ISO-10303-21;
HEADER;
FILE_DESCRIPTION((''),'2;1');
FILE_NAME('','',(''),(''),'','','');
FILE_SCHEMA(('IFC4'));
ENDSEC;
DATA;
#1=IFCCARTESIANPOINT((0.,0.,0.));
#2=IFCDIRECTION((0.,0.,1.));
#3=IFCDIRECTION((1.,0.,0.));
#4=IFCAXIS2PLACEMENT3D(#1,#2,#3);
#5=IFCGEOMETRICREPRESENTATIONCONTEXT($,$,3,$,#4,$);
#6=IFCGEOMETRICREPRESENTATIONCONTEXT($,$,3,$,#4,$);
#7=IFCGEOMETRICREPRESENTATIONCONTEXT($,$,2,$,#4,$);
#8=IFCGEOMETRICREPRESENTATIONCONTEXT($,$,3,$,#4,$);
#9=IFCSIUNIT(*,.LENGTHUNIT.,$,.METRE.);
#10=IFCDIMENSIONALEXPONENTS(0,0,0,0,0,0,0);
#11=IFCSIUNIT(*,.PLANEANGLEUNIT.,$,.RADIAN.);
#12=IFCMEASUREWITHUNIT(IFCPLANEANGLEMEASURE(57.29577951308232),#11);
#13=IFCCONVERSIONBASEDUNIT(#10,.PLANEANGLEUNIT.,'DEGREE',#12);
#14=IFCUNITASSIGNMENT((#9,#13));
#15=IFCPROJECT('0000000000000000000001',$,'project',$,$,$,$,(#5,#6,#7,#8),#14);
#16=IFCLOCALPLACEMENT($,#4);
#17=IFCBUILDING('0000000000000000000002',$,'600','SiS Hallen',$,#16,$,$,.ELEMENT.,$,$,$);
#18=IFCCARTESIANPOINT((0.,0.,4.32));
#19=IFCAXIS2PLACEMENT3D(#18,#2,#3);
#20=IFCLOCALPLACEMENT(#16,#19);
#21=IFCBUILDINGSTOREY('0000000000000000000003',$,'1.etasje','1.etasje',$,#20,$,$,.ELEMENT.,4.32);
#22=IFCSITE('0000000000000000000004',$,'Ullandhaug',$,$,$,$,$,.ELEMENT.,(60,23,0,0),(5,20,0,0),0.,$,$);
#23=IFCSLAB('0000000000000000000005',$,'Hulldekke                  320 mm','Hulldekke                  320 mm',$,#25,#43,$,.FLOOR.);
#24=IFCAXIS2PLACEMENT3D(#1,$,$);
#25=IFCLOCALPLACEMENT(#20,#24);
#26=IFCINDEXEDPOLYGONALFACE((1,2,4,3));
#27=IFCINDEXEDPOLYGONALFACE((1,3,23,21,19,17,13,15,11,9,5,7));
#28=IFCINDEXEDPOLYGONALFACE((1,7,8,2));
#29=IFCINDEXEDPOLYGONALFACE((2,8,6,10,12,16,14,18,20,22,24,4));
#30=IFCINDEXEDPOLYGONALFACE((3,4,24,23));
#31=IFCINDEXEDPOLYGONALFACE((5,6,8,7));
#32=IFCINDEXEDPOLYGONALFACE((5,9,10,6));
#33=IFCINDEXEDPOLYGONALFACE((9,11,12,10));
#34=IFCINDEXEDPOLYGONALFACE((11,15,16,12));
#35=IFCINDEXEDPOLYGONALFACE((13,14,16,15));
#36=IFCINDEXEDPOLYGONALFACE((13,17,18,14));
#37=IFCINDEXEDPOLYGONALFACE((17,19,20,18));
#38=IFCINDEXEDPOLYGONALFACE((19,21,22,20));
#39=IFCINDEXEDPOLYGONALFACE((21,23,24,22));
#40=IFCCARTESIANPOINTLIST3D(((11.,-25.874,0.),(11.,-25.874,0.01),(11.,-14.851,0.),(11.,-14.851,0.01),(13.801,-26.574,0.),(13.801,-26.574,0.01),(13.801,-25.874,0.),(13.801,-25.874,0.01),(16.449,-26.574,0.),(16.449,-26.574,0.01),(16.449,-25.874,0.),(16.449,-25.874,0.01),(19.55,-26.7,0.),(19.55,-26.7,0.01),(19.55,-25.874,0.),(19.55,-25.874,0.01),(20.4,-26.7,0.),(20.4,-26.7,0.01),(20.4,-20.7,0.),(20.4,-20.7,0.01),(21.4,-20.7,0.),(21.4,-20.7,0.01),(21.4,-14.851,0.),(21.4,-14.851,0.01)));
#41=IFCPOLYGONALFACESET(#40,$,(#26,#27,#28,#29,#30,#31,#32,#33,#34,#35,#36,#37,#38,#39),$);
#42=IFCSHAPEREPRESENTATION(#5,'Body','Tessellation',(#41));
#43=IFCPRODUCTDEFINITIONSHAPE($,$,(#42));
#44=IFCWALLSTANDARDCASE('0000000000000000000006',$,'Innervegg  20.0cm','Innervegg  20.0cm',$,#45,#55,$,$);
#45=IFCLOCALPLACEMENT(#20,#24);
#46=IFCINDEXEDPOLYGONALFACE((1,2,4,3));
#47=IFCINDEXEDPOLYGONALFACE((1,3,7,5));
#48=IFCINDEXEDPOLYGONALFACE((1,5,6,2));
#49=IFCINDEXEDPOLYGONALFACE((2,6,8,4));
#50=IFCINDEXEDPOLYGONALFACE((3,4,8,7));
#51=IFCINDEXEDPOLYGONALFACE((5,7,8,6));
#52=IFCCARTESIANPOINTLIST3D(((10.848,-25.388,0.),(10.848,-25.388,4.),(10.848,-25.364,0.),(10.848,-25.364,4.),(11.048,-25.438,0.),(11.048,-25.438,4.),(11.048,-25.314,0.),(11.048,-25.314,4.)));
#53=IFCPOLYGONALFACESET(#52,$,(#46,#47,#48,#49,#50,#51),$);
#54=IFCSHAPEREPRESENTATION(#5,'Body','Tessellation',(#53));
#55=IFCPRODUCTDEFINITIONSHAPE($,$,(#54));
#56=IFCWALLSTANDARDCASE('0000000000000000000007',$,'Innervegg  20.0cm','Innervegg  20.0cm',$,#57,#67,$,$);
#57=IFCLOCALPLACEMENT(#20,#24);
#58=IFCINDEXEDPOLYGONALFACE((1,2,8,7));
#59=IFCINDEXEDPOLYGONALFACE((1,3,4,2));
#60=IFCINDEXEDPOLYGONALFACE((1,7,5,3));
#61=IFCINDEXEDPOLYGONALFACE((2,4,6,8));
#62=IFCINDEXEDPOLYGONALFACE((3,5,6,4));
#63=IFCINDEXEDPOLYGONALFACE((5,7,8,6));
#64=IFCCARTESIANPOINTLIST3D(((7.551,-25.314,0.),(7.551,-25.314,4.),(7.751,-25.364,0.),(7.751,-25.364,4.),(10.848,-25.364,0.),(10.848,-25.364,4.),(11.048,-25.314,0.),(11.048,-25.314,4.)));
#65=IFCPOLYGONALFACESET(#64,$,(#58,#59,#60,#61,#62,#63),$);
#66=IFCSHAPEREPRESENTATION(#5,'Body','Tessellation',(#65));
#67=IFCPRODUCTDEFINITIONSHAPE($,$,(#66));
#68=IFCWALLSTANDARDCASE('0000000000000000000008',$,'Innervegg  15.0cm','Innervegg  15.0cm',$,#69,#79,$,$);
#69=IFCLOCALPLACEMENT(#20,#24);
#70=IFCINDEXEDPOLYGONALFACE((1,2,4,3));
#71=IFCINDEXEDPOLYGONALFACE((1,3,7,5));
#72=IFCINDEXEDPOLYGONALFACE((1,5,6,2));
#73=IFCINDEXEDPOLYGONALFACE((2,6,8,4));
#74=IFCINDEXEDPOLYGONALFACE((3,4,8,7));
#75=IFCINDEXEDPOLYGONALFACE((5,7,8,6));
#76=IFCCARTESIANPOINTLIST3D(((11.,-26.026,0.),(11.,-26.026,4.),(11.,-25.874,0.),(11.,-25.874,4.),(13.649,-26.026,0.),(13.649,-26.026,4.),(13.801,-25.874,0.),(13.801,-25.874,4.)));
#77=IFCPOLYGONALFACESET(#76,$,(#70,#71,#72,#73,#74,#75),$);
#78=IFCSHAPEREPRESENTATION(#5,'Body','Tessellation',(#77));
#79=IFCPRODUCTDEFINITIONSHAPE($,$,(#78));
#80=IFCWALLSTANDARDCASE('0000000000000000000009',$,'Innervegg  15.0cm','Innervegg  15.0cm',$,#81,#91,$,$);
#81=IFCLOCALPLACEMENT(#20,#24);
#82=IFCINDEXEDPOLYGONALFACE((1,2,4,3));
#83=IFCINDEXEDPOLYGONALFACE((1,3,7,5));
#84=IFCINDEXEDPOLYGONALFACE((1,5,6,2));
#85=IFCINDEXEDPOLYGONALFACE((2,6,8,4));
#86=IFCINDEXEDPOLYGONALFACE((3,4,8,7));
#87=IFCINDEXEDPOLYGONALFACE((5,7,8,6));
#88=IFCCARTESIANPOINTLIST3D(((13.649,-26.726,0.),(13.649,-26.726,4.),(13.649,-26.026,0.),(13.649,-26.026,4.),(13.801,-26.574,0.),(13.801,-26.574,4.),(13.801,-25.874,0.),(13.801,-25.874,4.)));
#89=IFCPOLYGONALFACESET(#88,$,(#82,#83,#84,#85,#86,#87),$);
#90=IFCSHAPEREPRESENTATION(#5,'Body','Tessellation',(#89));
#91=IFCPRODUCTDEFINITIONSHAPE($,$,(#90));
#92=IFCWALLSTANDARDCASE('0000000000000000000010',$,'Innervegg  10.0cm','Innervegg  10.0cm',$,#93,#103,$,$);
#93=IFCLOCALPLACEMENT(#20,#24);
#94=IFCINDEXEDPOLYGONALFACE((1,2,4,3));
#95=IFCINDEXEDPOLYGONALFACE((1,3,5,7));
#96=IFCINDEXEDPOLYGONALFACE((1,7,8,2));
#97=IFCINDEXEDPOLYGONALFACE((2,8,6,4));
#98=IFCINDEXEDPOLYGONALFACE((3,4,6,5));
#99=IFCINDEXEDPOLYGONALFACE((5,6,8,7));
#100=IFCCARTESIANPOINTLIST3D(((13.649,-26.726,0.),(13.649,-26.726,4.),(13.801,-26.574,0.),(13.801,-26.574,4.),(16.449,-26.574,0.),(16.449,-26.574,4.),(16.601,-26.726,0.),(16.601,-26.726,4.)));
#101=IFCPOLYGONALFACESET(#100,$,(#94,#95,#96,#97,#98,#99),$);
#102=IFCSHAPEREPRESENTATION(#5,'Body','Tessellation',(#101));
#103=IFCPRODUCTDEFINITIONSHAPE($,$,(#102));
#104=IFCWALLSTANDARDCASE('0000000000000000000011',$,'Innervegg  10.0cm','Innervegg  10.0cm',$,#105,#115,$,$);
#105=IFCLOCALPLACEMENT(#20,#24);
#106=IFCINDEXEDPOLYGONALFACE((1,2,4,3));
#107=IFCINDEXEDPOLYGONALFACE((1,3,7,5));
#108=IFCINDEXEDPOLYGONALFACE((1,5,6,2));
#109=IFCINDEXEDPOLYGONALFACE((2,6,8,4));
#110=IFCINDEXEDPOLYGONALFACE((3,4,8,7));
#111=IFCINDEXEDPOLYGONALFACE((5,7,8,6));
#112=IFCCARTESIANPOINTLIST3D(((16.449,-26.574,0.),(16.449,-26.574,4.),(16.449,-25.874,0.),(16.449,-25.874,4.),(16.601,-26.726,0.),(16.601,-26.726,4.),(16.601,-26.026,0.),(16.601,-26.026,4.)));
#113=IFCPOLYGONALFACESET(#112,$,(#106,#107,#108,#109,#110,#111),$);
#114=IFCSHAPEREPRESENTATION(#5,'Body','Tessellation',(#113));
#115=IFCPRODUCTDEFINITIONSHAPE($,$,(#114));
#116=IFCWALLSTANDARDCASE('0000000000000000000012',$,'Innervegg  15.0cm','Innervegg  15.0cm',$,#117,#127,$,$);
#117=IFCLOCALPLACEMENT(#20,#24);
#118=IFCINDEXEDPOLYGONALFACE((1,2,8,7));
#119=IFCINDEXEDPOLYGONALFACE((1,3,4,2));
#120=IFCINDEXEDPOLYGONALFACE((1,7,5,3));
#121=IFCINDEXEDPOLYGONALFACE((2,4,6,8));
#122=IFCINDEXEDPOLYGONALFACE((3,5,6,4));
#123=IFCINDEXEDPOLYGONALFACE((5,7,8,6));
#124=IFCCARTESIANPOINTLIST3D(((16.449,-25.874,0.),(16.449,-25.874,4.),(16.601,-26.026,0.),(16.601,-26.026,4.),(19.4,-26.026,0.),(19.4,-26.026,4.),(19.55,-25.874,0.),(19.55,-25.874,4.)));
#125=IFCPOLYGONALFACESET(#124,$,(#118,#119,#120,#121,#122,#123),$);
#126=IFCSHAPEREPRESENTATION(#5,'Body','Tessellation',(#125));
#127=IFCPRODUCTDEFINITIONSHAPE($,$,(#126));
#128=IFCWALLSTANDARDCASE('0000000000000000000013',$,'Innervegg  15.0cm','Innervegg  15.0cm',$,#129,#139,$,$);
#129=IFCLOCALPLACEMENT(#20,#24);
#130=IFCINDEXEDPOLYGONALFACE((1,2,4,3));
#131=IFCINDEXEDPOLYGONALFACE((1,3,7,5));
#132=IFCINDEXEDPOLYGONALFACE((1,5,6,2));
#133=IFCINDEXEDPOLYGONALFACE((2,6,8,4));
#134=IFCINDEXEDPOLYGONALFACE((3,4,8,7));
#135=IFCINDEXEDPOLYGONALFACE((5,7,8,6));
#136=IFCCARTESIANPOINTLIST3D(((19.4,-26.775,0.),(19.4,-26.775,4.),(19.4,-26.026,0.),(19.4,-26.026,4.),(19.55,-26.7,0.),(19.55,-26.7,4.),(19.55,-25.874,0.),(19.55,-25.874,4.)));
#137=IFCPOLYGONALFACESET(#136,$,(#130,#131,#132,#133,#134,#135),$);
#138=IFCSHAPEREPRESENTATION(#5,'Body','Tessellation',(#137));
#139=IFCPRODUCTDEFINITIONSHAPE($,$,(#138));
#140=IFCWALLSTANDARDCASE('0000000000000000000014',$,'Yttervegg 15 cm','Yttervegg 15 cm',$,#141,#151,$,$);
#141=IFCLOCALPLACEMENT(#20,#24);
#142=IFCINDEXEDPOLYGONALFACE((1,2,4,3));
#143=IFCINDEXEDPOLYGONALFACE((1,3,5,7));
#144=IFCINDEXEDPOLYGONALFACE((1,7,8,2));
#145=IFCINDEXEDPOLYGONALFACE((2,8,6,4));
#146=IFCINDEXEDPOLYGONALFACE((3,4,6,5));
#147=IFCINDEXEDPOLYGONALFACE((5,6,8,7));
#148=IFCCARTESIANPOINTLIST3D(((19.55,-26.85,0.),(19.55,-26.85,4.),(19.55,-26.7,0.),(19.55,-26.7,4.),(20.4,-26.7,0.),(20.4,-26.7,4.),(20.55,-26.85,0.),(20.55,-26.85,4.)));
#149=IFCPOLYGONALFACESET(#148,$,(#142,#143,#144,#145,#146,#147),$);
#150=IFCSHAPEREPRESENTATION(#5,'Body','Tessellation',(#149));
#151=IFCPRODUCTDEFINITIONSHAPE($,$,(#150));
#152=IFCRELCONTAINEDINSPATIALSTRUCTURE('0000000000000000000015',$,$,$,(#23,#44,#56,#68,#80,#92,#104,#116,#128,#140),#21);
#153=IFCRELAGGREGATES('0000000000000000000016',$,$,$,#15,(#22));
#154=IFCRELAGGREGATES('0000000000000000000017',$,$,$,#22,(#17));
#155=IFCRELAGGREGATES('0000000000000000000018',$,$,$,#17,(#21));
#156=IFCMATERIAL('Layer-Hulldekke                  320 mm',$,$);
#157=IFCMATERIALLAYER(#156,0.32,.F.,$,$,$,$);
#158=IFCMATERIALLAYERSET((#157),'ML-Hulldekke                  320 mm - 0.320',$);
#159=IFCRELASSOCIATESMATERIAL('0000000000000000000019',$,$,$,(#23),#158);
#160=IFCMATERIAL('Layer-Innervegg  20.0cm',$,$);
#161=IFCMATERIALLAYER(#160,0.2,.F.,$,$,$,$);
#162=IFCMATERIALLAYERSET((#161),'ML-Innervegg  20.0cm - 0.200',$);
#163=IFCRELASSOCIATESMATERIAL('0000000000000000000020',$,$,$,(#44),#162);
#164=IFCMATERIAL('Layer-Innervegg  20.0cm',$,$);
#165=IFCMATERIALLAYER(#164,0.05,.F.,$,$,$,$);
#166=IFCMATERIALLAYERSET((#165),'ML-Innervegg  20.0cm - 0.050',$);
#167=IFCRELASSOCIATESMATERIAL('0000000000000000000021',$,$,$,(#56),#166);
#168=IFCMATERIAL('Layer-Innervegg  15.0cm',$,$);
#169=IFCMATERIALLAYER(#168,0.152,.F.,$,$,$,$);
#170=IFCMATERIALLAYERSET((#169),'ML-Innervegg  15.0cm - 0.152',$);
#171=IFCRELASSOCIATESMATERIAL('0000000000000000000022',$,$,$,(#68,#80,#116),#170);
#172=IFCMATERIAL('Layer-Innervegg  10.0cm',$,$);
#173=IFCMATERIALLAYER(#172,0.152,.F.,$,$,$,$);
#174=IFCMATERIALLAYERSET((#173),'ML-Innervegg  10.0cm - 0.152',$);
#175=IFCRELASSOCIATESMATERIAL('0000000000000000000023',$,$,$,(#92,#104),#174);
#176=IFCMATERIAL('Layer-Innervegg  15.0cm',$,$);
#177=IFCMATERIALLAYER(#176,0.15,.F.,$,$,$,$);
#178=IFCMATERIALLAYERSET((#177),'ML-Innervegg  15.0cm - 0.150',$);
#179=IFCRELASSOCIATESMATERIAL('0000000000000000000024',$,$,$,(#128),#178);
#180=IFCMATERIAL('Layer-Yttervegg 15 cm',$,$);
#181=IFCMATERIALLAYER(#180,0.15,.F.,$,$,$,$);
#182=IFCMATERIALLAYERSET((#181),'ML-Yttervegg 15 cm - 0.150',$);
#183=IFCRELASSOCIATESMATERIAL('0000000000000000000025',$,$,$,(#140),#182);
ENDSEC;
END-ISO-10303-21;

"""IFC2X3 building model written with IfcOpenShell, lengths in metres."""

from ifc_helpers import new_model, entity, si_unit, converted_unit, frame, origin_with_axes, place, context, project, spatial, polyline, outline, extrude, material, layer, layer_set, layer_usage, element, save


model = new_model("IFC2X3")

# Units and contexts
context_of_model_1 = context(None, 3, world=origin_with_axes())
context_of_model_2 = context(None, 3, world=origin_with_axes())
context_of_model_3 = context(None, 2, world=origin_with_axes())
context_of_model_4 = context(None, 3, world=origin_with_axes())
ifc_project = project(units=[si_unit("LENGTHUNIT", "METRE"), converted_unit("PLANEANGLEUNIT", "DEGREE", entity("IfcPlaneAngleMeasure", 57.29577951308232), si_unit("PLANEANGLEUNIT", "RADIAN"), dimensions=[0, 0, 0, 0, 0, 0, 0])], contexts=[context_of_model_1, context_of_model_2, context_of_model_3, context_of_model_4])

# Site, building, storey
site = spatial("IfcSite", under=ifc_project, Name="Ullandhaug", CompositionType="ELEMENT", RefLatitude=(60, 23, 0, 0), RefLongitude=(5, 20, 0, 0), RefElevation=0.0)
building_placement = place(None, origin_with_axes())
building = spatial("IfcBuilding", under=site, at=building_placement, Name="600", Description="SiS Hallen", CompositionType="ELEMENT")
storey_placement = place(building_placement, frame((0.0, 0.0, 4.32), z_axis=(0.0, 0.0, 1.0), x_axis=(1.0, 0.0, 0.0)))
storey = spatial("IfcBuildingStorey", under=building, at=storey_placement, Name="1.etasje", Description="1.etasje", CompositionType="ELEMENT", Elevation=4.32)

# Slab
ifc_material_1 = material(Name="Layer-Hulldekke                  320 mm")
ifc_layer_1 = layer(ifc_material_1, 0.32, ventilated=False)
ifc_layer_set_1 = layer_set([ifc_layer_1], Name="ML-Hulldekke                  320 mm - 0.320")
ifc_layer_usage_1 = layer_usage(ifc_layer_set_1, "AXIS2", "POSITIVE", 0.0)
slab_placement = place(storey_placement, frame((11.0, -25.874, 0.0), z_axis=(0.0, 0.0, 1.0), x_axis=(1.0, 0.0, 0.0)))
element("IfcSlab", 1, at=slab_placement, inside=storey, material=ifc_layer_usage_1, Name="Hulldekke                  320 mm", Description="Hulldekke                  320 mm", PredefinedType="FLOOR", context=context_of_model_1, shape_type="SweptSolid", body=[
    extrude(outline(polyline([(0.0, 0.0), (2.801, 0.0), (2.801, 0.7), (5.449, 0.7), (5.449, 0.0), (8.55, 0.0), (8.55, 0.826), (9.4, 0.826), (9.4, -5.174), (10.4, -5.174), (10.4, -11.023), (0.0, -11.023), (0.0, 0.0)])), frame((0.0, 0.0, 0.0), z_axis=(0.0, 0.0, -1.0), x_axis=(1.0, 0.0, 0.0)), (0.0, 0.0, -1.0), 0.01),
])

# Walls
ifc_material_2 = material(Name="Layer-Innervegg  20.0cm")
ifc_layer_2 = layer(ifc_material_2, 0.2, ventilated=False)
ifc_layer_set_2 = layer_set([ifc_layer_2], Name="ML-Innervegg  20.0cm - 0.200")
ifc_layer_usage_2 = layer_usage(ifc_layer_set_2, "AXIS2", "POSITIVE", 0.0)
wall_1_placement = place(storey_placement, frame((11.048, -25.438, 0.0), z_axis=(0.0, 0.0, 1.0), x_axis=(0.0, 1.0, 0.0)))
element("IfcWallStandardCase", 2, at=wall_1_placement, inside=storey, material=ifc_layer_usage_2, Name="Innervegg  20.0cm", Description="Innervegg  20.0cm", context=context_of_model_1, shape_type="SweptSolid", body=[
    extrude(outline(polyline([(0.0, 0.0), (0.124, 0.0), (0.074, 0.2), (0.05, 0.2), (0.0, 0.0)])), frame((0.0, 0.0, 0.0), z_axis=(0.0, 0.0, 1.0), x_axis=(1.0, 0.0, 0.0)), (0.0, 0.0, 1.0), 4.0),
])
ifc_material_3 = material(Name="Layer-Innervegg  20.0cm")
ifc_layer_3 = layer(ifc_material_3, 0.05, ventilated=False)
ifc_layer_set_3 = layer_set([ifc_layer_3], Name="ML-Innervegg  20.0cm - 0.050")
ifc_layer_usage_3 = layer_usage(ifc_layer_set_3, "AXIS2", "POSITIVE", 0.0)
wall_2_placement = place(storey_placement, frame((11.048, -25.314, 0.0), z_axis=(0.0, 0.0, 1.0), x_axis=(-1.0, 0.0, 0.0)))
element("IfcWallStandardCase", 3, at=wall_2_placement, inside=storey, material=ifc_layer_usage_3, Name="Innervegg  20.0cm", Description="Innervegg  20.0cm", context=context_of_model_1, shape_type="SweptSolid", body=[
    extrude(outline(polyline([(0.0, 0.0), (3.497, 0.0), (3.297, 0.05), (0.2, 0.05), (0.0, 0.0)])), frame((0.0, 0.0, 0.0), z_axis=(0.0, 0.0, 1.0), x_axis=(1.0, 0.0, 0.0)), (0.0, 0.0, 1.0), 4.0),
])
ifc_material_4 = material(Name="Layer-Innervegg  15.0cm")
ifc_layer_4 = layer(ifc_material_4, 0.152, ventilated=False)
ifc_layer_set_4 = layer_set([ifc_layer_4], Name="ML-Innervegg  15.0cm - 0.152")
ifc_layer_usage_4 = layer_usage(ifc_layer_set_4, "AXIS2", "POSITIVE", 0.0)
wall_3_placement = place(storey_placement, frame((11.0, -26.026, 0.0), z_axis=(0.0, 0.0, 1.0), x_axis=(1.0, 0.0, 0.0)))
element("IfcWallStandardCase", 4, at=wall_3_placement, inside=storey, material=ifc_layer_usage_4, Name="Innervegg  15.0cm", Description="Innervegg  15.0cm", context=context_of_model_1, shape_type="SweptSolid", body=[
    extrude(outline(polyline([(0.0, 0.0), (2.649, 0.0), (2.801, 0.152), (0.0, 0.152), (0.0, 0.0)])), origin_with_axes(), (0.0, 0.0, 1.0), 4.0),
])
wall_4_placement = place(storey_placement, frame((13.649, -26.026, 0.0), z_axis=(0.0, 0.0, 1.0), x_axis=(0.0, -1.0, 0.0)))
element("IfcWallStandardCase", 5, at=wall_4_placement, inside=storey, material=ifc_layer_usage_4, Name="Innervegg  15.0cm", Description="Innervegg  15.0cm", context=context_of_model_1, shape_type="SweptSolid", body=[
    extrude(outline(polyline([(0.0, 0.0), (0.7, 0.0), (0.548, 0.152), (-0.152, 0.152), (0.0, 0.0)])), frame((0.0, 0.0, 0.0), z_axis=(0.0, 0.0, 1.0), x_axis=(1.0, 0.0, 0.0)), (0.0, 0.0, 1.0), 4.0),
])
ifc_material_5 = material(Name="Layer-Innervegg  10.0cm")
ifc_layer_5 = layer(ifc_material_5, 0.152, ventilated=False)
ifc_layer_set_5 = layer_set([ifc_layer_5], Name="ML-Innervegg  10.0cm - 0.152")
ifc_layer_usage_5 = layer_usage(ifc_layer_set_5, "AXIS2", "POSITIVE", 0.0)
wall_5_placement = place(storey_placement, frame((13.649, -26.726, 0.0), z_axis=(0.0, 0.0, 1.0), x_axis=(1.0, 0.0, 0.0)))
element("IfcWallStandardCase", 6, at=wall_5_placement, inside=storey, material=ifc_layer_usage_5, Name="Innervegg  10.0cm", Description="Innervegg  10.0cm", context=context_of_model_1, shape_type="SweptSolid", body=[
    extrude(outline(polyline([(0.0, 0.0), (2.952, 0.0), (2.8, 0.152), (0.152, 0.152), (0.0, 0.0)])), origin_with_axes(), (0.0, 0.0, 1.0), 4.0),
])
wall_6_placement = place(storey_placement, frame((16.601, -26.726, 0.0), z_axis=(0.0, 0.0, 1.0), x_axis=(0.0, 1.0, 0.0)))
element("IfcWallStandardCase", 7, at=wall_6_placement, inside=storey, material=ifc_layer_usage_5, Name="Innervegg  10.0cm", Description="Innervegg  10.0cm", context=context_of_model_1, shape_type="SweptSolid", body=[
    extrude(outline(polyline([(0.0, 0.0), (0.7, 0.0), (0.852, 0.152), (0.152, 0.152), (0.0, 0.0)])), frame((0.0, 0.0, 0.0), z_axis=(0.0, 0.0, 1.0), x_axis=(1.0, 0.0, 0.0)), (0.0, 0.0, 1.0), 4.0),
])
wall_7_placement = place(storey_placement, frame((16.601, -26.026, 0.0), z_axis=(0.0, 0.0, 1.0), x_axis=(1.0, 0.0, 0.0)))
element("IfcWallStandardCase", 8, at=wall_7_placement, inside=storey, material=ifc_layer_usage_4, Name="Innervegg  15.0cm", Description="Innervegg  15.0cm", context=context_of_model_1, shape_type="SweptSolid", body=[
    extrude(outline(polyline([(0.0, 0.0), (2.799, 0.0), (2.949, 0.152), (-0.152, 0.152), (0.0, 0.0)])), origin_with_axes(), (0.0, 0.0, 1.0), 4.0),
])
ifc_material_6 = material(Name="Layer-Innervegg  15.0cm")
ifc_layer_6 = layer(ifc_material_6, 0.15, ventilated=False)
ifc_layer_set_6 = layer_set([ifc_layer_6], Name="ML-Innervegg  15.0cm - 0.150")
ifc_layer_usage_6 = layer_usage(ifc_layer_set_6, "AXIS2", "POSITIVE", 0.0)
wall_8_placement = place(storey_placement, frame((19.4, -26.026, 0.0), z_axis=(0.0, 0.0, 1.0), x_axis=(0.0, -1.0, 0.0)))
element("IfcWallStandardCase", 9, at=wall_8_placement, inside=storey, material=ifc_layer_usage_6, Name="Innervegg  15.0cm", Description="Innervegg  15.0cm", context=context_of_model_1, shape_type="SweptSolid", body=[
    extrude(outline(polyline([(0.0, 0.0), (0.749, 0.0), (0.674, 0.15), (-0.152, 0.15), (0.0, 0.0)])), frame((0.0, 0.0, 0.0), z_axis=(0.0, 0.0, 1.0), x_axis=(1.0, 0.0, 0.0)), (0.0, 0.0, 1.0), 4.0),
])
ifc_material_7 = material(Name="Layer-Yttervegg 15 cm")
ifc_layer_7 = layer(ifc_material_7, 0.15, ventilated=False)
ifc_layer_set_7 = layer_set([ifc_layer_7], Name="ML-Yttervegg 15 cm - 0.150")
ifc_layer_usage_7 = layer_usage(ifc_layer_set_7, "AXIS2", "POSITIVE", 0.0)
wall_9_placement = place(storey_placement, frame((19.55, -26.85, 0.0), z_axis=(0.0, 0.0, 1.0), x_axis=(1.0, 0.0, 0.0)))
element("IfcWallStandardCase", 10, at=wall_9_placement, inside=storey, material=ifc_layer_usage_7, Name="Yttervegg 15 cm", Description="Yttervegg 15 cm", context=context_of_model_1, shape_type="SweptSolid", body=[
    extrude(outline(polyline([(0.0, 0.0), (1.0, 0.0), (0.85, 0.15), (0.0, 0.15), (0.0, 0.0)])), origin_with_axes(), (0.0, 0.0, 1.0), 4.0),
])

save(model, "model.ifc")
